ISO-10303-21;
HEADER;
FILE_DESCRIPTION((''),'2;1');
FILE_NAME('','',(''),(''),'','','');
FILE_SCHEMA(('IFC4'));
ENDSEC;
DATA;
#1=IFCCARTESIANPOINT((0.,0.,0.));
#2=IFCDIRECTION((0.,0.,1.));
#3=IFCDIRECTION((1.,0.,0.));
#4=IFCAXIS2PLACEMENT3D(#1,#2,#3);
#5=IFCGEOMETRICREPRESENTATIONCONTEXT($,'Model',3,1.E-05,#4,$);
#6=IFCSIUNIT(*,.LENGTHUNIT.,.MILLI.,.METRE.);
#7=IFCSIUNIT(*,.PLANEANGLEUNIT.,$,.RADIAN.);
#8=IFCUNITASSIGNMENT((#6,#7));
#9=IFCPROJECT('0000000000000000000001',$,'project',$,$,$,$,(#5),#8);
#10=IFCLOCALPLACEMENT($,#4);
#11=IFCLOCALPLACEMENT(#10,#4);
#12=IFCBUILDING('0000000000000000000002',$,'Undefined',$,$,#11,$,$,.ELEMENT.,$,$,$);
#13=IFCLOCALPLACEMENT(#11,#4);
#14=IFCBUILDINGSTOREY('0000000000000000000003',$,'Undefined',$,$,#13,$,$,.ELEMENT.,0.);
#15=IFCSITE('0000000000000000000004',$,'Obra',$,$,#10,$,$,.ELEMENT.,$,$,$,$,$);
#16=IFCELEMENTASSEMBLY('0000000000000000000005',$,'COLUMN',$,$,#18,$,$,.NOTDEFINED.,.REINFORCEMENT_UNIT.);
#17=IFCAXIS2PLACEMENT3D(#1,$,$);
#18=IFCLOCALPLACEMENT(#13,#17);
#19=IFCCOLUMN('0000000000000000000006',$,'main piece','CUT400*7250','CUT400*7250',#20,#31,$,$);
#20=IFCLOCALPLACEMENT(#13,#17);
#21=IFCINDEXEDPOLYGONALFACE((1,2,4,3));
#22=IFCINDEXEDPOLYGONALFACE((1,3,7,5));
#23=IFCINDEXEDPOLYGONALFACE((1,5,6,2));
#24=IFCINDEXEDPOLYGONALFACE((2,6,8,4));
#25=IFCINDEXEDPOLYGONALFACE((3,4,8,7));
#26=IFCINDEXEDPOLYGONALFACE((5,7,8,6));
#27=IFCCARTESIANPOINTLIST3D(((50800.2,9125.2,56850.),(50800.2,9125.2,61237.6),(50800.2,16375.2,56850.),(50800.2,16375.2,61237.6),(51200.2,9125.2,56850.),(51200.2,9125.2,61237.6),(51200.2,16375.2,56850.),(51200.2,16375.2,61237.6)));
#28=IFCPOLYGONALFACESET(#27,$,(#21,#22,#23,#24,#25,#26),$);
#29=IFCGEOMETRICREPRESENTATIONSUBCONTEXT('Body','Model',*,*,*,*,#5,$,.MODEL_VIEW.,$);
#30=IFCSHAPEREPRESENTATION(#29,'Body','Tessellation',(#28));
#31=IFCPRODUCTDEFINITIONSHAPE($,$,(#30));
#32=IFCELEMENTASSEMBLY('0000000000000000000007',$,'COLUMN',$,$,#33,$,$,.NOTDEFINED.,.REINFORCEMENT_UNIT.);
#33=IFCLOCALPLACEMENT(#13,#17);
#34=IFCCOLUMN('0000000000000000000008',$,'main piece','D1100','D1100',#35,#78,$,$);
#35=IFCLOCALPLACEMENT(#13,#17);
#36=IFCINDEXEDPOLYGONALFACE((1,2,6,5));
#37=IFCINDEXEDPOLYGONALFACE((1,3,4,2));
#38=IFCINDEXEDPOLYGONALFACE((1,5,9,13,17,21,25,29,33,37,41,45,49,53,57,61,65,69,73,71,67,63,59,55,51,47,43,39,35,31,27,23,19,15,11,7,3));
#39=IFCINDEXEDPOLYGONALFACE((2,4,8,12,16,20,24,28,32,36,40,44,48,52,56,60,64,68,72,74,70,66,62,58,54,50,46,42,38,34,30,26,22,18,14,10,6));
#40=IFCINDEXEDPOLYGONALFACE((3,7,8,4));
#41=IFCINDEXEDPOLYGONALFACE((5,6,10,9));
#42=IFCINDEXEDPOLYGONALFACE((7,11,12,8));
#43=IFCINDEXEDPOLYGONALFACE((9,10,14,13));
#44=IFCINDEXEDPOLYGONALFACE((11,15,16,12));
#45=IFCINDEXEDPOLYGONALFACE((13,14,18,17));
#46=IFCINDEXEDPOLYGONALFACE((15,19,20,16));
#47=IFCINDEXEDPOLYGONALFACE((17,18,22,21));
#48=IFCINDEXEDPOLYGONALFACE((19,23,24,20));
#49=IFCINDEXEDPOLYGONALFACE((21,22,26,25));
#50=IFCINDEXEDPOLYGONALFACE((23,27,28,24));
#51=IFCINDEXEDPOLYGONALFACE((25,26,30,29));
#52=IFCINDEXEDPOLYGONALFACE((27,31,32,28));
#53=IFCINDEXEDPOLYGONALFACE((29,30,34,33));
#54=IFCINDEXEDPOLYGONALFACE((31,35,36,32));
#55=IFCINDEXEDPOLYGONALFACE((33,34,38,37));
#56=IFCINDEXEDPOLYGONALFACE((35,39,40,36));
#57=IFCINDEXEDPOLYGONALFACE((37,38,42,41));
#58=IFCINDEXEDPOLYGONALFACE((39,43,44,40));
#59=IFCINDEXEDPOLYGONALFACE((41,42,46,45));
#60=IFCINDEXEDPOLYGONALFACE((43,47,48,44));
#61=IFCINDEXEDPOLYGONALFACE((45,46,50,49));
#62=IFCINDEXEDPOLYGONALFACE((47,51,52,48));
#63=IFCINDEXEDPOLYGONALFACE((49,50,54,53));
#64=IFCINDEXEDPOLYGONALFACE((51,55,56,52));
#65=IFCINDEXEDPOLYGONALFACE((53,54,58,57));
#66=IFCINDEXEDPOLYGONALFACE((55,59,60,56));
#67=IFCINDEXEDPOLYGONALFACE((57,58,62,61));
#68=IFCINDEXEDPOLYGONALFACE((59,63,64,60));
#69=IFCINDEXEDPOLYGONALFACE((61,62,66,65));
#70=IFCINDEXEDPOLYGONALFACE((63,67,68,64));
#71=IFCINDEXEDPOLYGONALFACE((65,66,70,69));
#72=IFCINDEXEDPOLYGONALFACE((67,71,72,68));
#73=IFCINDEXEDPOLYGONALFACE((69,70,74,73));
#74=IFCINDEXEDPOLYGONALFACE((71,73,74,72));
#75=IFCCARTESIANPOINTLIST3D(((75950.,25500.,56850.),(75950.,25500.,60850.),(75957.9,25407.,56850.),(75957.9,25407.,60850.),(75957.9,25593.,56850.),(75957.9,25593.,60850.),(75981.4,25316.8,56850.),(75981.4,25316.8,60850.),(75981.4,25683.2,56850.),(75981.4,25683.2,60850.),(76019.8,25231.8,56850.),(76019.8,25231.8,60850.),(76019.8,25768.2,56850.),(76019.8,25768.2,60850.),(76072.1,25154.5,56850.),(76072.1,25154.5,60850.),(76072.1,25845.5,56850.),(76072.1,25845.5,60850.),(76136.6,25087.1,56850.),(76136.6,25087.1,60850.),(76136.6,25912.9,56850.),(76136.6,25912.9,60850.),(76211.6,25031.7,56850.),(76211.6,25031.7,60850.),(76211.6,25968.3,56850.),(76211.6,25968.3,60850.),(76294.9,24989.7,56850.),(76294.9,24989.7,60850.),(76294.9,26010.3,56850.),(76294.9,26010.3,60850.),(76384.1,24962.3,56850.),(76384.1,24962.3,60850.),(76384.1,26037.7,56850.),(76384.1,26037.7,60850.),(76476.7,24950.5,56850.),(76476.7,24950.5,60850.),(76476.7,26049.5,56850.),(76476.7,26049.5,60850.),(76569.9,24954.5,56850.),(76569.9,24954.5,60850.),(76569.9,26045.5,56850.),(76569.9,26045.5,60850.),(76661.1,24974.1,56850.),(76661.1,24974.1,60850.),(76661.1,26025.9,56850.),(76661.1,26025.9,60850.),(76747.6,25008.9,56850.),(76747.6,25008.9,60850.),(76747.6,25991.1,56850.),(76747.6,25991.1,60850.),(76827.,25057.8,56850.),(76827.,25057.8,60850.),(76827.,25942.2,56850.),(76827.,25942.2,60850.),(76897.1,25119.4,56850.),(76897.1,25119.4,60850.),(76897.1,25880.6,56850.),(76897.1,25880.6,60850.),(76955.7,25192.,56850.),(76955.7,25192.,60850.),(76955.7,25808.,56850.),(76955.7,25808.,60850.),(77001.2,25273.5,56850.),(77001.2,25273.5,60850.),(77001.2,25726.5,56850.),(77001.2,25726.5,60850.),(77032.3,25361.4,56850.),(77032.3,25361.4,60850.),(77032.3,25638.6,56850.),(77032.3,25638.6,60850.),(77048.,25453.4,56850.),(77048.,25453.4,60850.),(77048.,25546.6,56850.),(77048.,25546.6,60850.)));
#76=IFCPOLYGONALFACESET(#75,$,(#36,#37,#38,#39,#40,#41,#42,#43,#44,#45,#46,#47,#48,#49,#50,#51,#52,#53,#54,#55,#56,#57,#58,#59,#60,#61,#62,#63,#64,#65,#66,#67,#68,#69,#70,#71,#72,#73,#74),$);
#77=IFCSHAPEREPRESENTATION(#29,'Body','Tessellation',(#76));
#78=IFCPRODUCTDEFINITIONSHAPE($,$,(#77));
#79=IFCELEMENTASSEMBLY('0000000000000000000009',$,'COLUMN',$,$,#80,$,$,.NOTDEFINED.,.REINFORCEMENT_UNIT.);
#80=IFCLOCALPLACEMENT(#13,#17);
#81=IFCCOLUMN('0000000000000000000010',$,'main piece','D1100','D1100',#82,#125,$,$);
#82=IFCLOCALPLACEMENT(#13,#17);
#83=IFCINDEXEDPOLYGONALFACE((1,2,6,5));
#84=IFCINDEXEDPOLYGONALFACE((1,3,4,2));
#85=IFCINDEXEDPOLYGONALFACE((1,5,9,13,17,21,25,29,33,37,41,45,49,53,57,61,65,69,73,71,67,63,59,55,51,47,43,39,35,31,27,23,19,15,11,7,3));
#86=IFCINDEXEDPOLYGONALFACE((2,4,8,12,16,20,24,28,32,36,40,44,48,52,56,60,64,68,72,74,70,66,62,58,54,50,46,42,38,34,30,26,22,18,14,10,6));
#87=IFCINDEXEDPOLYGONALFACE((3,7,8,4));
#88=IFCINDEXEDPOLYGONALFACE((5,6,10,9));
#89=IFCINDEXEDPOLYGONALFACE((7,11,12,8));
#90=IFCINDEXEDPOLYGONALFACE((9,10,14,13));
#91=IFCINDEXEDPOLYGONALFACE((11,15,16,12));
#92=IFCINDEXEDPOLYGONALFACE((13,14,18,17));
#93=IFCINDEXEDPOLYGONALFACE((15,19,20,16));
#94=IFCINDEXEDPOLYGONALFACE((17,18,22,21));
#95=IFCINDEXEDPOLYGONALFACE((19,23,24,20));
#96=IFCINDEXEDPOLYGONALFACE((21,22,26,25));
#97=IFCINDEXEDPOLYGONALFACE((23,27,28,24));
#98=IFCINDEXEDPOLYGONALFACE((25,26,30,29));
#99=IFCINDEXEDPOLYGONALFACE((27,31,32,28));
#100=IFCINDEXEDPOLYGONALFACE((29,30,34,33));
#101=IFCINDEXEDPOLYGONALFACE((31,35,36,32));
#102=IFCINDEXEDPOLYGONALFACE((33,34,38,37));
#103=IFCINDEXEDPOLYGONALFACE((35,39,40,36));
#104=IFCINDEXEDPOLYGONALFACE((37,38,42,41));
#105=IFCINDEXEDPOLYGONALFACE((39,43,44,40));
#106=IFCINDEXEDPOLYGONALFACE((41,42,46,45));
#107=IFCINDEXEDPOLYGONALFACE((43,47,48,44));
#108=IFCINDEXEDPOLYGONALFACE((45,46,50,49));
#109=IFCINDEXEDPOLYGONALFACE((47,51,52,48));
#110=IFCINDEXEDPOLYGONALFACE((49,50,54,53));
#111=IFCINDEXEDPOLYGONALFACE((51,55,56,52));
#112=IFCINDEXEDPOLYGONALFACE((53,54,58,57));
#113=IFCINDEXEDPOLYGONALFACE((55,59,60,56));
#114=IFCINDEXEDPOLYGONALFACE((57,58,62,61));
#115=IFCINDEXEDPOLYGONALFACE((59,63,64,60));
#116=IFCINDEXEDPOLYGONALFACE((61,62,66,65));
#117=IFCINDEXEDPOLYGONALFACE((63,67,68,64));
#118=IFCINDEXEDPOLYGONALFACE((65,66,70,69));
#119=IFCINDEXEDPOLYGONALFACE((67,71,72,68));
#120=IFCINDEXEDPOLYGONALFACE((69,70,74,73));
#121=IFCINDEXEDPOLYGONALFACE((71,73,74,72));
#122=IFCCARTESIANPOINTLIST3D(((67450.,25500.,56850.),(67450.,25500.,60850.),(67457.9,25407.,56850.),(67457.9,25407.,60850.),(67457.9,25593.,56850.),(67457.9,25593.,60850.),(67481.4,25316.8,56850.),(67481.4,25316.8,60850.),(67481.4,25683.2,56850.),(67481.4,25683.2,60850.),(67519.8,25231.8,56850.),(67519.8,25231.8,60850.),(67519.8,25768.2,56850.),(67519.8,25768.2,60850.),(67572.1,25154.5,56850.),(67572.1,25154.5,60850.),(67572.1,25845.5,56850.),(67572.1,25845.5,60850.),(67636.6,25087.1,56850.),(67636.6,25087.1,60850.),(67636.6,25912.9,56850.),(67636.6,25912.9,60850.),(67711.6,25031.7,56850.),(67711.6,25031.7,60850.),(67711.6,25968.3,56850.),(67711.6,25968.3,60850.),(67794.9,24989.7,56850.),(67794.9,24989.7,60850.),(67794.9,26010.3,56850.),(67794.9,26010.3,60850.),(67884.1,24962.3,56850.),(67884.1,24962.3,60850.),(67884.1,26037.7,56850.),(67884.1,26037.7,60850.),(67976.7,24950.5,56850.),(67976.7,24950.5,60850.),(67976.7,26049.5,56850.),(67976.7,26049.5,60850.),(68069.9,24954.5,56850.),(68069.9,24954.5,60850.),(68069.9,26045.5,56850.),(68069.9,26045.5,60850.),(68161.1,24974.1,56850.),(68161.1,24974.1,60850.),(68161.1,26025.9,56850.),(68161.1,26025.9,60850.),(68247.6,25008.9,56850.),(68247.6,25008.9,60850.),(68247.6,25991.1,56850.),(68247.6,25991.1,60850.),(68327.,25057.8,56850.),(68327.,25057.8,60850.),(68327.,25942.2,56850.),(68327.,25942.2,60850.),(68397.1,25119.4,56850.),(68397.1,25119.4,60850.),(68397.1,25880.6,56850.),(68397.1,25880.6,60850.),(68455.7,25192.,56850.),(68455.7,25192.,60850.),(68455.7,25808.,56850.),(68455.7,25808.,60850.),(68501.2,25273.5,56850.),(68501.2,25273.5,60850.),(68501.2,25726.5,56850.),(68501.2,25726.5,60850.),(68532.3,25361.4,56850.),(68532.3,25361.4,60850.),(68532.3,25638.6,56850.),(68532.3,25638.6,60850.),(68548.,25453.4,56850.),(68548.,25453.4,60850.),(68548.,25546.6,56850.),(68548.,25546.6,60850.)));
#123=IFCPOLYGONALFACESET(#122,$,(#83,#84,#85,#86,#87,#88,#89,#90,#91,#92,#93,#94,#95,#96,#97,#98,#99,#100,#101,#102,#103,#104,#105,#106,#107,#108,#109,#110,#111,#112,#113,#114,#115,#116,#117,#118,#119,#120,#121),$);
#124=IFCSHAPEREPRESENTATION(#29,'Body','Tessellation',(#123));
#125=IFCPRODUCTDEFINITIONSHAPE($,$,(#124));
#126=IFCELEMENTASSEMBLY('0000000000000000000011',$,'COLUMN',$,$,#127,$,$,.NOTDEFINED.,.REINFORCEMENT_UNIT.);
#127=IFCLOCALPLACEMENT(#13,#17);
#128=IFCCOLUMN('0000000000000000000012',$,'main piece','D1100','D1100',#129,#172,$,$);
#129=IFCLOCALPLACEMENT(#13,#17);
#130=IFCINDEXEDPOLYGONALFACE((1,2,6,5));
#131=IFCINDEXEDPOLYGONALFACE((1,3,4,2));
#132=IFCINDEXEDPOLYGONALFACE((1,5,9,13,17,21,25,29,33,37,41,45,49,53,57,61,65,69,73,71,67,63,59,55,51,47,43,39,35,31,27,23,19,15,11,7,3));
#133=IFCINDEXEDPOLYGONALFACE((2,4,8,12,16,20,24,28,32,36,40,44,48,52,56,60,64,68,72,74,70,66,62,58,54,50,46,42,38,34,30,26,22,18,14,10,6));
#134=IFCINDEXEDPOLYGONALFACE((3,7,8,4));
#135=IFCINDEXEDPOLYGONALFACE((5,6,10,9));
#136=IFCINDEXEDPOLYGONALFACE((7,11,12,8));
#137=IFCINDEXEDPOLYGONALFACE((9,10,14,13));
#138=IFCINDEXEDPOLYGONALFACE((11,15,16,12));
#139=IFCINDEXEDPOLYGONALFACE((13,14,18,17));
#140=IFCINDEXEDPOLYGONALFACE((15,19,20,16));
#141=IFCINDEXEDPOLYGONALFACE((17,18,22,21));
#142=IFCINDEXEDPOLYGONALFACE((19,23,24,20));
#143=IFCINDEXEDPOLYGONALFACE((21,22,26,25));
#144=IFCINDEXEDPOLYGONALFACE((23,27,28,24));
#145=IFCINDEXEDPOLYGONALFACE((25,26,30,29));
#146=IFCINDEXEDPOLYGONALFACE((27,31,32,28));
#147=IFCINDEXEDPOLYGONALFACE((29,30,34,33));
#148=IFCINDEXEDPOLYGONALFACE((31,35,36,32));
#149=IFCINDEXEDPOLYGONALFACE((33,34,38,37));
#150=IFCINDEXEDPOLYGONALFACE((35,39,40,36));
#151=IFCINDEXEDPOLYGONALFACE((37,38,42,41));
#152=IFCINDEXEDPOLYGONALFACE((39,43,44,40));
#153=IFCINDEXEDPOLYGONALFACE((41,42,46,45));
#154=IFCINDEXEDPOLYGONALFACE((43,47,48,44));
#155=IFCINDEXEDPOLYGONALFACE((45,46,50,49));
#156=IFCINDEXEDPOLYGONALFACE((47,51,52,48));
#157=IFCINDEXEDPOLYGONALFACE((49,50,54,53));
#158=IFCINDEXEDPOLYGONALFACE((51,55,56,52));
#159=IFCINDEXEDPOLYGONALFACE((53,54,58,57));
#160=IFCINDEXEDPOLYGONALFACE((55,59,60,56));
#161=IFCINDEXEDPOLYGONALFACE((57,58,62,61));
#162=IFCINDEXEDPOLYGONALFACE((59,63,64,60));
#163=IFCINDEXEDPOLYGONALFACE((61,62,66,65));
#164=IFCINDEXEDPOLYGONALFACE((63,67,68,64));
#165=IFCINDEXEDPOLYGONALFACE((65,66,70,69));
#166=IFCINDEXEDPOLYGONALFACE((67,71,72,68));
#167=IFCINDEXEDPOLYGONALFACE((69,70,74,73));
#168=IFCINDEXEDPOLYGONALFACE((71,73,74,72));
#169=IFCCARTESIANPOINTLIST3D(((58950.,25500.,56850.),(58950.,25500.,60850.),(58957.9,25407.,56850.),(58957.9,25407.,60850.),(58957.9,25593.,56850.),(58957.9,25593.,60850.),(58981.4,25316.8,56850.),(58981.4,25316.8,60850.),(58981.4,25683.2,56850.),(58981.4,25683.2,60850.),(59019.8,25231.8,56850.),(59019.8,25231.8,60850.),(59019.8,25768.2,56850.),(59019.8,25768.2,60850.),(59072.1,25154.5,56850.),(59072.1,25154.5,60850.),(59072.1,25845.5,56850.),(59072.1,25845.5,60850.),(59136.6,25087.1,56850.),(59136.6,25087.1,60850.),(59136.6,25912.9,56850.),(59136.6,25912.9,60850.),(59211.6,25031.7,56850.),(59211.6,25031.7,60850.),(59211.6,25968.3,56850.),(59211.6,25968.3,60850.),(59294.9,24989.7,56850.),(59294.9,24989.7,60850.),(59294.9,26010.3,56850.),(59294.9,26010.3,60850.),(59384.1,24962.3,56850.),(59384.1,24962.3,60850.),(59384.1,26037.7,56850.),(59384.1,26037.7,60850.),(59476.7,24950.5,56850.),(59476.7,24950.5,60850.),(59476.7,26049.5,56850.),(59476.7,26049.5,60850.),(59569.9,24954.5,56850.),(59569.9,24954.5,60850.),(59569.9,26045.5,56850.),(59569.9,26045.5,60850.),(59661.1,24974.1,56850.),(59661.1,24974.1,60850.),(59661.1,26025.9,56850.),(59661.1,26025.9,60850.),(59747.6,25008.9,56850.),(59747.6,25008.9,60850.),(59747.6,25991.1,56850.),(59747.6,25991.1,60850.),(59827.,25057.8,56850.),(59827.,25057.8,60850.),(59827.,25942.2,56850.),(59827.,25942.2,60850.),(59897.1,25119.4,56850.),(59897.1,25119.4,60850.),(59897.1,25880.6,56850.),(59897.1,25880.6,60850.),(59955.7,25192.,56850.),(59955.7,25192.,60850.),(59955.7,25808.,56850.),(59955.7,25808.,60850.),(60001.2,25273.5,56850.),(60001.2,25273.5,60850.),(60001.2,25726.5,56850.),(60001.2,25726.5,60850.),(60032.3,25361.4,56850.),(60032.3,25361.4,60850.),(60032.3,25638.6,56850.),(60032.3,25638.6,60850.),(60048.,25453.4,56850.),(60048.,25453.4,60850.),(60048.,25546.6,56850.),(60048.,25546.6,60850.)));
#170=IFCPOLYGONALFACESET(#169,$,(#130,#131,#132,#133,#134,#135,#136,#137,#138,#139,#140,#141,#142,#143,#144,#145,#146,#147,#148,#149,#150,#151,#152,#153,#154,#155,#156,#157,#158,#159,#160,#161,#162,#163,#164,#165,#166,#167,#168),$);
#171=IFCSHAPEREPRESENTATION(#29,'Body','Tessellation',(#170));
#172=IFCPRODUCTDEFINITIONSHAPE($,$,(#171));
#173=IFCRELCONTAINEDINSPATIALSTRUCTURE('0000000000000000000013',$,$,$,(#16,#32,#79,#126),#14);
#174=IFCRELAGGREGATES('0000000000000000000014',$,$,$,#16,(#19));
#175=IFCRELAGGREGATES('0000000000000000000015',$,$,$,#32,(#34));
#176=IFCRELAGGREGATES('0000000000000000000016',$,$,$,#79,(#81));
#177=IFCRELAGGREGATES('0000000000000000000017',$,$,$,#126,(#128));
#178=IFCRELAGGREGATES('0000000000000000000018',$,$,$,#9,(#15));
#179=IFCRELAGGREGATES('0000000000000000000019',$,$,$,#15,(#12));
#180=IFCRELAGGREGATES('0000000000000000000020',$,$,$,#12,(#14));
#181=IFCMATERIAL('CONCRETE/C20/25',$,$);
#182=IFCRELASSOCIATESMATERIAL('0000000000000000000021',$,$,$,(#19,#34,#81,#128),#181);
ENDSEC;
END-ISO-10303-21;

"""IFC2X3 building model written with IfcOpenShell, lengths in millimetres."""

from ifc_helpers import new_model, si_unit, frame, origin_with_axes, origin_2d_with_axis, place, context, subcontext, project, spatial, rectangle, circle, extrude, material, element, aggregate, save


model = new_model("IFC2X3")

# Units and contexts
model_context = context("Model", 3, precision=1e-05, world=origin_with_axes())
body_context = subcontext(model_context, "Body", "Model", "MODEL_VIEW")
ifc_project = project(units=[si_unit("LENGTHUNIT", "METRE", prefix="MILLI"), si_unit("PLANEANGLEUNIT", "RADIAN")], contexts=[model_context])

# Site, building, storey
site_placement = place(None, origin_with_axes())
site = spatial("IfcSite", under=ifc_project, at=site_placement, Name="Obra", CompositionType="ELEMENT")
building_placement = place(site_placement, origin_with_axes())
building = spatial("IfcBuilding", under=site, at=building_placement, Name="Undefined", CompositionType="ELEMENT")
storey_placement = place(building_placement, origin_with_axes())
storey = spatial("IfcBuildingStorey", under=building, at=storey_placement, Name="Undefined", CompositionType="ELEMENT", Elevation=0.0)

# Element assemblies, columns
assembly_1_placement = place(storey_placement, origin_with_axes())
assembly_1 = element("IfcElementAssembly", 1, at=assembly_1_placement, inside=storey, Name="COLUMN", AssemblyPlace="NOTDEFINED", PredefinedType="REINFORCEMENT_UNIT")
ifc_material_1 = material(Name="CONCRETE/C20/25")
column_1_placement = place(assembly_1_placement, frame((51000.2, 12750.2, 56850.0), z_axis=(0.0, 0.0, 1.0), x_axis=(0.0, -1.0, 0.0)))
column_1 = element("IfcColumn", 2, at=column_1_placement, material=ifc_material_1, Name="main piece", Description="CUT400*7250", ObjectType="CUT400*7250", context=body_context, shape_type="SweptSolid", body=[
    extrude(rectangle(XDim=400.0, YDim=7250.0, at=origin_2d_with_axis()), frame((0.0, 0.0, 4387.6), z_axis=(0.0, 0.0, -1.0), x_axis=(0.0, 1.0, 0.0)), (0.0, 0.0, 1.0), 4387.6),
])
aggregate(assembly_1, [column_1])
assembly_2_placement = place(storey_placement, origin_with_axes())
assembly_2 = element("IfcElementAssembly", 3, at=assembly_2_placement, inside=storey, Name="COLUMN", AssemblyPlace="NOTDEFINED", PredefinedType="REINFORCEMENT_UNIT")
column_2_placement = place(assembly_2_placement, frame((76500.0, 25500.0, 56850.0), z_axis=(0.0, 0.0, 1.0), x_axis=(0.0, 1.0, 0.0)))
column_2 = element("IfcColumn", 4, at=column_2_placement, material=ifc_material_1, Name="main piece", Description="D1100", ObjectType="D1100", context=body_context, shape_type="SweptSolid", body=[
    extrude(circle(Radius=550.0, at=origin_2d_with_axis()), frame((0.0, 0.0, 4000.0), z_axis=(0.0, 0.0, -1.0), x_axis=(0.0, 1.0, 0.0)), (0.0, 0.0, 1.0), 4000.0),
])
aggregate(assembly_2, [column_2])
assembly_3_placement = place(storey_placement, origin_with_axes())
assembly_3 = element("IfcElementAssembly", 5, at=assembly_3_placement, inside=storey, Name="COLUMN", AssemblyPlace="NOTDEFINED", PredefinedType="REINFORCEMENT_UNIT")
column_3_placement = place(assembly_3_placement, frame((68000.0, 25500.0, 56850.0), z_axis=(0.0, 0.0, 1.0), x_axis=(0.0, 1.0, 0.0)))
column_3 = element("IfcColumn", 6, at=column_3_placement, material=ifc_material_1, Name="main piece", Description="D1100", ObjectType="D1100", context=body_context, shape_type="SweptSolid", body=[
    extrude(circle(Radius=550.0, at=origin_2d_with_axis()), frame((0.0, 0.0, 4000.0), z_axis=(0.0, 0.0, -1.0), x_axis=(0.0, 1.0, 0.0)), (0.0, 0.0, 1.0), 4000.0),
])
aggregate(assembly_3, [column_3])
assembly_4_placement = place(storey_placement, origin_with_axes())
assembly_4 = element("IfcElementAssembly", 7, at=assembly_4_placement, inside=storey, Name="COLUMN", AssemblyPlace="NOTDEFINED", PredefinedType="REINFORCEMENT_UNIT")
column_4_placement = place(assembly_4_placement, frame((59500.0, 25500.0, 56850.0), z_axis=(0.0, 0.0, 1.0), x_axis=(0.0, 1.0, 0.0)))
column_4 = element("IfcColumn", 8, at=column_4_placement, material=ifc_material_1, Name="main piece", Description="D1100", ObjectType="D1100", context=body_context, shape_type="SweptSolid", body=[
    extrude(circle(Radius=550.0, at=origin_2d_with_axis()), frame((0.0, 0.0, 4000.0), z_axis=(0.0, 0.0, -1.0), x_axis=(0.0, 1.0, 0.0)), (0.0, 0.0, 1.0), 4000.0),
])
aggregate(assembly_4, [column_4])

save(model, "model.ifc")
